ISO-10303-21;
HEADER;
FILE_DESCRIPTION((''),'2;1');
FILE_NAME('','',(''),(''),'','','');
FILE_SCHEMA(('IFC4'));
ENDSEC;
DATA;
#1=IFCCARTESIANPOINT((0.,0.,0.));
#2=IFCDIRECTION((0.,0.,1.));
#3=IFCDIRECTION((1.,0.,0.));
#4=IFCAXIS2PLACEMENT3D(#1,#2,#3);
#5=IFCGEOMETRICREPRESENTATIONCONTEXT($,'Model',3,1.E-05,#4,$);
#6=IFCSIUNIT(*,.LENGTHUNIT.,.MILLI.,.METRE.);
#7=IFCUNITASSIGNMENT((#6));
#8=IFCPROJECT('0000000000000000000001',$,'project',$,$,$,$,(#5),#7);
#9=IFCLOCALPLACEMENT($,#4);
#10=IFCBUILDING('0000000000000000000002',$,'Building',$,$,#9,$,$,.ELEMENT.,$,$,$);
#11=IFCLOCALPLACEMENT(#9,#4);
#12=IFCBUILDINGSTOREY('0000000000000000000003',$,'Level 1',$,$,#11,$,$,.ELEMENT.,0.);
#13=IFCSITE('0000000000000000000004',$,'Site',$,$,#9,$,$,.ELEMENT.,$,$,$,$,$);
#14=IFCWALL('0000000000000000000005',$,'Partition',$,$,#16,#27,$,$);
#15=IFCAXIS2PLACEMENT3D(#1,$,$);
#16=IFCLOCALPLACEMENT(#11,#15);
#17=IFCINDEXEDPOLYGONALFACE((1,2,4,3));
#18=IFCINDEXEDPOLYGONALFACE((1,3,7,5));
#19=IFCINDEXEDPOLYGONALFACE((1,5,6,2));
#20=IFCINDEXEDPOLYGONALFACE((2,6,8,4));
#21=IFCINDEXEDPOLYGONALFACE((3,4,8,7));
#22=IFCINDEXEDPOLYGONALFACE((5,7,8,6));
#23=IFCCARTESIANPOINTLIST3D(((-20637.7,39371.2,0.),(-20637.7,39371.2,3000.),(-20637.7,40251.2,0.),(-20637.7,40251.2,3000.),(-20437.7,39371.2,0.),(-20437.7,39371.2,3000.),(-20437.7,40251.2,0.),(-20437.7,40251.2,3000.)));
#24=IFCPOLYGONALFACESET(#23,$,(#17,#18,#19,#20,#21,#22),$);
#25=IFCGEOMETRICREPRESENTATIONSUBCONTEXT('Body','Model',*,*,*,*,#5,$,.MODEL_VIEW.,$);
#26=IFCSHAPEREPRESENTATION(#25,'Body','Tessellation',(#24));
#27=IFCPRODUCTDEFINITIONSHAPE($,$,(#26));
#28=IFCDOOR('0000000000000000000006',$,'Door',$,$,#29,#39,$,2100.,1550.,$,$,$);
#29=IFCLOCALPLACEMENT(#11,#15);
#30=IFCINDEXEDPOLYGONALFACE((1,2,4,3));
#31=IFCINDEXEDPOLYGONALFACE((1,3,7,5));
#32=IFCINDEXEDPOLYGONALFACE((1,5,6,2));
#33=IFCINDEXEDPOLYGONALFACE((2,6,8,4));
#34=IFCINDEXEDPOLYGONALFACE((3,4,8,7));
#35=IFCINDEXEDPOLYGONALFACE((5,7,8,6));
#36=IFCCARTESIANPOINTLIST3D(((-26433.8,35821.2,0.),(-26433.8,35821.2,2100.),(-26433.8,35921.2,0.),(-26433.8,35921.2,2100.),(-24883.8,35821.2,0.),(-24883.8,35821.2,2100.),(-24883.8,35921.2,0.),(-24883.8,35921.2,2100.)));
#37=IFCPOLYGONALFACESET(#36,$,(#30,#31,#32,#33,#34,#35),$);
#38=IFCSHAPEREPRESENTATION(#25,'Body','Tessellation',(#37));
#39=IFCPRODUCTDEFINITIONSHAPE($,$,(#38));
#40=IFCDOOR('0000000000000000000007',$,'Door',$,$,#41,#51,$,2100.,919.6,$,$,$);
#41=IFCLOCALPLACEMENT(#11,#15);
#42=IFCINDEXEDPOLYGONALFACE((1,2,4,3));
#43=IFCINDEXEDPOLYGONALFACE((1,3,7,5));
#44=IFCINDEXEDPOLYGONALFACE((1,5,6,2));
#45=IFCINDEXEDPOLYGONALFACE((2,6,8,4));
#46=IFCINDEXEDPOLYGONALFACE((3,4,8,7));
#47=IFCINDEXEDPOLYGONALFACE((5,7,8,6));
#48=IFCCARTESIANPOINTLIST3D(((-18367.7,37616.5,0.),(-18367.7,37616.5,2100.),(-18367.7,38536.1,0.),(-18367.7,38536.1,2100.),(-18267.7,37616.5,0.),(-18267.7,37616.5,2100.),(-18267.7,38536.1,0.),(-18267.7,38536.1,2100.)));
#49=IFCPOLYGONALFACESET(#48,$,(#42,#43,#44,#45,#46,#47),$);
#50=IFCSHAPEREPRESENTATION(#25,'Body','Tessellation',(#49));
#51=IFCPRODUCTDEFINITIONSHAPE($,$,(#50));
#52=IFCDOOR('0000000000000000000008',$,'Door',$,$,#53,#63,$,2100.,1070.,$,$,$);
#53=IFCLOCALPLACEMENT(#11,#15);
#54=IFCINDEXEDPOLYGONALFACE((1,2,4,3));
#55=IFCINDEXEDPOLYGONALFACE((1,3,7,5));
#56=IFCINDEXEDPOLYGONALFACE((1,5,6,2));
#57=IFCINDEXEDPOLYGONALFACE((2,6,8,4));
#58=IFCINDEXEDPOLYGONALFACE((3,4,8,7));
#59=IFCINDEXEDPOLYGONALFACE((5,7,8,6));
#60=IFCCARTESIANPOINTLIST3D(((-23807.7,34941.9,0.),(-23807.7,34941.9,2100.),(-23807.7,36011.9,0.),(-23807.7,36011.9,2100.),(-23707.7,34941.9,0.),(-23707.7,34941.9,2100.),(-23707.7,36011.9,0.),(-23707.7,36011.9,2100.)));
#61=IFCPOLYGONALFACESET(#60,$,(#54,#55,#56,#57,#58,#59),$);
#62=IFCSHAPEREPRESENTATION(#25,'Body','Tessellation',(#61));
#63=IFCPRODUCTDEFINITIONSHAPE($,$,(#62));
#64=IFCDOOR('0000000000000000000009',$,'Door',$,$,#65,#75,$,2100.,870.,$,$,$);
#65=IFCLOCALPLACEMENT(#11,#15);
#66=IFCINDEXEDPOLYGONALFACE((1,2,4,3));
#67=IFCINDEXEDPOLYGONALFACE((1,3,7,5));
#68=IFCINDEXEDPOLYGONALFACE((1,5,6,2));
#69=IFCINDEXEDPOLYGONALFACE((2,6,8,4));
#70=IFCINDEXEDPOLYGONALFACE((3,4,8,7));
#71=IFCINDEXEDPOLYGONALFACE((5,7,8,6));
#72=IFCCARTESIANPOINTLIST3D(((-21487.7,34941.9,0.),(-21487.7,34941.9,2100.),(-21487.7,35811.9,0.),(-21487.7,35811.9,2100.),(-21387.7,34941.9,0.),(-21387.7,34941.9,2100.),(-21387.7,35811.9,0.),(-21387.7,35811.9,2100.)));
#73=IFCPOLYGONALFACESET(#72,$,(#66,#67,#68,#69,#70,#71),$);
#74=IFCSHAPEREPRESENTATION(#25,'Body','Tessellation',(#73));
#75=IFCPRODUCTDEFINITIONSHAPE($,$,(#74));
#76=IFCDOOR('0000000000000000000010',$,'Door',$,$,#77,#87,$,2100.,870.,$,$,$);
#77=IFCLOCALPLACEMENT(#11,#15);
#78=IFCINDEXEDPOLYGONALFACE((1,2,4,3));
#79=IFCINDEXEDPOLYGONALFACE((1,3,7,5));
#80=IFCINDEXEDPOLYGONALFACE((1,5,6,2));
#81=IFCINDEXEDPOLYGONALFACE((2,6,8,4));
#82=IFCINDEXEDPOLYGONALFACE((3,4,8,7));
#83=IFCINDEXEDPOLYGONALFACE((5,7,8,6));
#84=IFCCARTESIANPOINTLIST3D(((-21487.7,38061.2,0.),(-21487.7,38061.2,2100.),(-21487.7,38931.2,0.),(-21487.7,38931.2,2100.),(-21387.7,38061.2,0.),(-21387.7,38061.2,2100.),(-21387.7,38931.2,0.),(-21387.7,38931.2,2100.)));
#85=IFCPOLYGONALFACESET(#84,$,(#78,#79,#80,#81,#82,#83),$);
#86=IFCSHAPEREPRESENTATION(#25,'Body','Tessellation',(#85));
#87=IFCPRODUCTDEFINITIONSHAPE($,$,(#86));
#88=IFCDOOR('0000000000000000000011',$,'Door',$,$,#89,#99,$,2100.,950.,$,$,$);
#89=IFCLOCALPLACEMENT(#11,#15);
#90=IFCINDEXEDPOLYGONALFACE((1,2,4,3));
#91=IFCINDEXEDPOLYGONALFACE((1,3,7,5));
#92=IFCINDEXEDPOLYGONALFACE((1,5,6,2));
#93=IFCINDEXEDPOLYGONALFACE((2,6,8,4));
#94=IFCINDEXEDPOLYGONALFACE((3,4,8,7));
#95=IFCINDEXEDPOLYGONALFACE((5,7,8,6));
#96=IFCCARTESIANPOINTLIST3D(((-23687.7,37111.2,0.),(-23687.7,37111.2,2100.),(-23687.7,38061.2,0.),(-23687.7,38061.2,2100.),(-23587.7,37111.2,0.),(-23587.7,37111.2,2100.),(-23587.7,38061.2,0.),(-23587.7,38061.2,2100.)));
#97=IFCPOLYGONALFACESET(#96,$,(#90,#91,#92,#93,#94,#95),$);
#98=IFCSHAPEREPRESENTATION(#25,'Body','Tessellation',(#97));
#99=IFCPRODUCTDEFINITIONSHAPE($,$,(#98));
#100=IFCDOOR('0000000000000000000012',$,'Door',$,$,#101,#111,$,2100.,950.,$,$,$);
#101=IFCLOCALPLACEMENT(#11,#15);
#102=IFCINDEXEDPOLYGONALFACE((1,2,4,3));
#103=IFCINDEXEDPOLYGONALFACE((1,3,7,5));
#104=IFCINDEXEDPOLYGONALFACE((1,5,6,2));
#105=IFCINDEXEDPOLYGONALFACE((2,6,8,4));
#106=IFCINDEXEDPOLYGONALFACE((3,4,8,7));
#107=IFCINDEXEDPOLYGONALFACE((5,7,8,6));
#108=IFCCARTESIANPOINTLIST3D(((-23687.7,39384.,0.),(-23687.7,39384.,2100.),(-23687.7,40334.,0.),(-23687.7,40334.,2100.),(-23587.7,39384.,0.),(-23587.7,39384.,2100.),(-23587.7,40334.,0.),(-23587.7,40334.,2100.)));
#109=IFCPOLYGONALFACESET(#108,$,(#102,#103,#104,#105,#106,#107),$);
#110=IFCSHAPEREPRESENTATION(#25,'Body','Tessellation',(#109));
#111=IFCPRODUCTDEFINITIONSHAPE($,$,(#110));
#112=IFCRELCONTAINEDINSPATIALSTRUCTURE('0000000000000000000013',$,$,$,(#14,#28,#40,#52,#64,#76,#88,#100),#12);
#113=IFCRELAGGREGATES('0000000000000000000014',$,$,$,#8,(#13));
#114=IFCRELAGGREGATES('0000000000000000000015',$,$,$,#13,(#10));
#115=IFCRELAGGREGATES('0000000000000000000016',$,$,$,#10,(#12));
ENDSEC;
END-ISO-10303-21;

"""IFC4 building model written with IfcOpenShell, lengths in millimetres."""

from ifc_helpers import new_model, si_unit, frame, frame_2d, origin_with_axes, place, context, subcontext, project, spatial, rectangle, extrude, element, save


model = new_model("IFC4")

# Units and contexts
model_context = context("Model", 3, precision=1e-05, world=origin_with_axes())
body_context = subcontext(model_context, "Body", "Model", "MODEL_VIEW")
ifc_project = project(units=[si_unit("LENGTHUNIT", "METRE", prefix="MILLI")], contexts=[model_context])

# Site, building, storey
placement = place(None, origin_with_axes())
site = spatial("IfcSite", under=ifc_project, at=placement, Name="Site", CompositionType="ELEMENT")
building = spatial("IfcBuilding", under=site, at=placement, Name="Building", CompositionType="ELEMENT")
storey_placement = place(placement, origin_with_axes())
storey = spatial("IfcBuildingStorey", under=building, at=storey_placement, Name="Level 1", CompositionType="ELEMENT", Elevation=0.0)

# Wall
wall_1_placement = place(placement, frame((-20537.7, 40251.2, 0.0), z_axis=(0.0, 0.0, 1.0), x_axis=(0.0, -1.0, 0.0)))
element("IfcWall", 1, at=wall_1_placement, inside=storey, Name="Partition", context=body_context, shape_type="SweptSolid", body=[
    extrude(rectangle(XDim=880.0, YDim=200.0, at=frame_2d((440.0, 0.0), x_axis=(1.0, 0.0))), origin_with_axes(), (0.0, 0.0, 1.0), 3000.0),
])

# Doors
door_1_placement = place(placement, frame((-26433.8, 35871.2, 0.0), z_axis=(0.0, 0.0, 1.0), x_axis=(1.0, 0.0, 0.0)))
element("IfcDoor", 2, at=door_1_placement, inside=storey, Name="Door", OverallHeight=2100.0, OverallWidth=1550.0, context=body_context, shape_type="SweptSolid", body=[
    extrude(rectangle(XDim=1550.0, YDim=100.0, at=frame_2d((775.0, 0.0), x_axis=(1.0, 0.0))), origin_with_axes(), (0.0, 0.0, 1.0), 2100.0),
])
door_2_placement = place(placement, frame((-18317.7, 37616.5, 0.0), z_axis=(0.0, 0.0, 1.0), x_axis=(0.0, 1.0, 0.0)))
element("IfcDoor", 3, at=door_2_placement, inside=storey, Name="Door", OverallHeight=2100.0, OverallWidth=919.6, context=body_context, shape_type="SweptSolid", body=[
    extrude(rectangle(XDim=919.6, YDim=100.0, at=frame_2d((459.8, 0.0), x_axis=(1.0, 0.0))), origin_with_axes(), (0.0, 0.0, 1.0), 2100.0),
])
door_3_placement = place(placement, frame((-23757.7, 34941.9, 0.0), z_axis=(0.0, 0.0, 1.0), x_axis=(0.0, 1.0, 0.0)))
element("IfcDoor", 4, at=door_3_placement, inside=storey, Name="Door", OverallHeight=2100.0, OverallWidth=1070.0, context=body_context, shape_type="SweptSolid", body=[
    extrude(rectangle(XDim=1070.0, YDim=100.0, at=frame_2d((535.0, 0.0), x_axis=(1.0, 0.0))), origin_with_axes(), (0.0, 0.0, 1.0), 2100.0),
])
for number, where, z_axis, x_axis, name in (
    (5, (-21437.7, 34941.9, 0.0), (0.0, 0.0, 1.0), (0.0, 1.0, 0.0), "Door"),
    (6, (-21437.7, 38061.2, 0.0), (0.0, 0.0, 1.0), (0.0, 1.0, 0.0), "Door"),
):
    element("IfcDoor", number, at=place(placement, frame(where, z_axis=z_axis, x_axis=x_axis)), inside=storey, Name=name, OverallHeight=2100.0, OverallWidth=870.0, context=body_context, shape_type="SweptSolid", body=[
        extrude(rectangle(XDim=870.0, YDim=100.0, at=frame_2d((435.0, 0.0), x_axis=(1.0, 0.0))), origin_with_axes(), (0.0, 0.0, 1.0), 2100.0),
    ])
for number, where, z_axis, x_axis, name in (
    (7, (-23637.7, 38061.2, 0.0), (0.0, 0.0, 1.0), (0.0, -1.0, 0.0), "Door"),
    (8, (-23637.7, 40334.0, 0.0), (0.0, 0.0, 1.0), (0.0, -1.0, 0.0), "Door"),
):
    element("IfcDoor", number, at=place(placement, frame(where, z_axis=z_axis, x_axis=x_axis)), inside=storey, Name=name, OverallHeight=2100.0, OverallWidth=950.0, context=body_context, shape_type="SweptSolid", body=[
        extrude(rectangle(XDim=950.0, YDim=100.0, at=frame_2d((475.0, 0.0), x_axis=(1.0, 0.0))), origin_with_axes(), (0.0, 0.0, 1.0), 2100.0),
    ])

save(model, "model.ifc")
